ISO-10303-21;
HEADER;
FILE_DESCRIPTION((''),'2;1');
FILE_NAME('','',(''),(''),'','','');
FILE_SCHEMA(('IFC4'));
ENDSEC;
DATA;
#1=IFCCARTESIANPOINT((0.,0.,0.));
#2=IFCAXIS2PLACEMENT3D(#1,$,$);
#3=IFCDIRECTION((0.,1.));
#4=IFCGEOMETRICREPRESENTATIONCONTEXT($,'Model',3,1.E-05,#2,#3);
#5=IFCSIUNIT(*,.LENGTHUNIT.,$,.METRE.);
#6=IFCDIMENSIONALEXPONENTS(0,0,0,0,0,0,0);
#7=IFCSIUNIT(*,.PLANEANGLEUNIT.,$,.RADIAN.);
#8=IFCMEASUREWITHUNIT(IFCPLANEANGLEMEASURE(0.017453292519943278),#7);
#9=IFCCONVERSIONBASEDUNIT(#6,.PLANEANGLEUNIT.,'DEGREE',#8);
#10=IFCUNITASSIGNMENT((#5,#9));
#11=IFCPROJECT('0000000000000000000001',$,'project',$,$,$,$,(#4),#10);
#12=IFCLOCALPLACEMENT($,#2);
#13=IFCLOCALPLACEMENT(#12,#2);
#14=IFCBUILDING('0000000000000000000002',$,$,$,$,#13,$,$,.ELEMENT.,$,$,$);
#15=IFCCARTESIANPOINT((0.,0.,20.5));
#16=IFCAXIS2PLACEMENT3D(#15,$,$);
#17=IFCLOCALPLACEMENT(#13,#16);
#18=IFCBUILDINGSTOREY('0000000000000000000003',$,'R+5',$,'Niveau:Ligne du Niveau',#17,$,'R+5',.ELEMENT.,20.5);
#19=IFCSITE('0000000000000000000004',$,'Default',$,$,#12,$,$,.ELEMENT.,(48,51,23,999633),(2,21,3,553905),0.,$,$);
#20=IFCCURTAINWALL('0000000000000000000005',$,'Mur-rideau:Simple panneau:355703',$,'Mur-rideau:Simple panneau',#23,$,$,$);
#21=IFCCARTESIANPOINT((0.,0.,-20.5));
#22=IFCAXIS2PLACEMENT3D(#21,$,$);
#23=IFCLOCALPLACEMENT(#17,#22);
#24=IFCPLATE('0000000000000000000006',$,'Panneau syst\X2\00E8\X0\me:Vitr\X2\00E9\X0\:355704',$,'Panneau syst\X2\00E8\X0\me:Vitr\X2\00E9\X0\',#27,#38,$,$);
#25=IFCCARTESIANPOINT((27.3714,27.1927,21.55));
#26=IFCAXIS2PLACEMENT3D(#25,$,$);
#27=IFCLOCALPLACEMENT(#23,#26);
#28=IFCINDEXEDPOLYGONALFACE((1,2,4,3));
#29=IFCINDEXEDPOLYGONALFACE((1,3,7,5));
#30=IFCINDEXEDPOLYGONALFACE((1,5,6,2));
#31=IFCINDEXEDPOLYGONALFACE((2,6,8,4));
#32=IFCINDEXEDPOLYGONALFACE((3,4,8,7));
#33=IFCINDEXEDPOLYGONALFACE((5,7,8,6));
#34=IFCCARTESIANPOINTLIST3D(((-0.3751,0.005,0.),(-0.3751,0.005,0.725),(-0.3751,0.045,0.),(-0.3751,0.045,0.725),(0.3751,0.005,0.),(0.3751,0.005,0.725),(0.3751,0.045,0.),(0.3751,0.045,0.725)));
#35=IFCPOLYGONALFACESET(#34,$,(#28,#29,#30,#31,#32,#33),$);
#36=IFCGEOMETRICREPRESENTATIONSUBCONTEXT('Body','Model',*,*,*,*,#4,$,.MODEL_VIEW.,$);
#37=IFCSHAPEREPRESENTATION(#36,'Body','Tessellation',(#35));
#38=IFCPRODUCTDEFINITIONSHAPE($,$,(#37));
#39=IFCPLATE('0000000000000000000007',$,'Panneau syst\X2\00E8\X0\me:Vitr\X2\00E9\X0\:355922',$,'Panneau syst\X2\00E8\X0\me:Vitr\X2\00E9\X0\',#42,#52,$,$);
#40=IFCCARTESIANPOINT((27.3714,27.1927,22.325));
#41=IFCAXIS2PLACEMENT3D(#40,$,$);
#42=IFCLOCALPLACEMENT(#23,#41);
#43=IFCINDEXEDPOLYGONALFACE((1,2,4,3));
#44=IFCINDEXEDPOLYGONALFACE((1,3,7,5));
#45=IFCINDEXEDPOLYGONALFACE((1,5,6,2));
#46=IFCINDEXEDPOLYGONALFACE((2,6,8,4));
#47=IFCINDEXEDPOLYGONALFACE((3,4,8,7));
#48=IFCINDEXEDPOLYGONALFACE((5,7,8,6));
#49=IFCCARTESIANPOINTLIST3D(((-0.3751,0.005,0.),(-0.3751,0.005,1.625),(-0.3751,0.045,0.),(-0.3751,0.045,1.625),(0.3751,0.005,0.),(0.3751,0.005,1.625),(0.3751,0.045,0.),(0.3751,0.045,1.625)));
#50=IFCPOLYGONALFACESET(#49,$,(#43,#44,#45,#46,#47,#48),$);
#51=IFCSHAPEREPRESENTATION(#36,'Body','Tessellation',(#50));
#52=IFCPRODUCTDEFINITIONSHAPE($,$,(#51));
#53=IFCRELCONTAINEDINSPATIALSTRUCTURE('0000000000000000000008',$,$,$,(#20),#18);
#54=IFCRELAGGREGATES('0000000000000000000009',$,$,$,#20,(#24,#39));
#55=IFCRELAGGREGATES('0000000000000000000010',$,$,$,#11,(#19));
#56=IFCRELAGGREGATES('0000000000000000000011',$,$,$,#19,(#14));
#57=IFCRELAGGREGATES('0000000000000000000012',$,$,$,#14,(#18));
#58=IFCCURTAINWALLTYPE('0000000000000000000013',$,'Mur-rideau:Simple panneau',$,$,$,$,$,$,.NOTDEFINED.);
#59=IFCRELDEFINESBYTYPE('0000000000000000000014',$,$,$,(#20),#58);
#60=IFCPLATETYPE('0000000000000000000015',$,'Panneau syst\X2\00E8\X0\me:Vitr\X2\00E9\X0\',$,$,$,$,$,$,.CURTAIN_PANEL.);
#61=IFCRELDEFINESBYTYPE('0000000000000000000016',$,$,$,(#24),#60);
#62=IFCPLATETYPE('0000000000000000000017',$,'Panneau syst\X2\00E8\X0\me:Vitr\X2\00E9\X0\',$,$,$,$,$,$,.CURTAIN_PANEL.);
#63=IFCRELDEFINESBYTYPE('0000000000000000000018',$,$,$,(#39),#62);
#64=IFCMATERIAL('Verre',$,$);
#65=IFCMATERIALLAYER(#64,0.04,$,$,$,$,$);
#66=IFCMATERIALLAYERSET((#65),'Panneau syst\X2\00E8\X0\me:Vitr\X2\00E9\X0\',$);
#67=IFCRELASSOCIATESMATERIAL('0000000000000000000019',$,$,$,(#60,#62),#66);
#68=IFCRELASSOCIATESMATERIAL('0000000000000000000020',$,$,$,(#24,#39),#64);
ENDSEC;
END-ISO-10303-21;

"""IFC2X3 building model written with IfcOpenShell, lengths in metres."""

from ifc_helpers import new_model, entity, si_unit, converted_unit, direction, frame, frame_2d, origin, place, context, subcontext, project, spatial, rectangle, extrude, source, transform, mapped, material, layer, layer_set, type_object, type_shapes, element, aggregate, save


model = new_model("IFC2X3")

# Units and contexts
model_context = context("Model", 3, precision=1e-05, world=origin(), true_north=direction((0.0, 1.0)))
body_context = subcontext(model_context, "Body", "Model", "MODEL_VIEW")
ifc_project = project(units=[si_unit("LENGTHUNIT", "METRE"), converted_unit("PLANEANGLEUNIT", "DEGREE", entity("IfcPlaneAngleMeasure", 0.017453292519943278), si_unit("PLANEANGLEUNIT", "RADIAN"), dimensions=[0, 0, 0, 0, 0, 0, 0])], contexts=[model_context])

# Site, building, storey
site_placement = place(None, origin())
site = spatial("IfcSite", under=ifc_project, at=site_placement, Name="Default", CompositionType="ELEMENT", RefLatitude=(48, 51, 23, 999633), RefLongitude=(2, 21, 3, 553905), RefElevation=0.0)
building_placement = place(site_placement, origin())
building = spatial("IfcBuilding", under=site, at=building_placement, CompositionType="ELEMENT")
storey_placement = place(building_placement, frame((0.0, 0.0, 20.5)))
storey = spatial("IfcBuildingStorey", under=building, at=storey_placement, Name="R+5", ObjectType="Niveau:Ligne du Niveau", LongName="R+5", CompositionType="ELEMENT", Elevation=20.5)

# Shared definitions
curtain_wall_type = type_object("IfcCurtainWallType", Name="Mur-rideau:Simple panneau", PredefinedType="NOTDEFINED")

# Curtain wall
curtain_wall_1_placement = place(storey_placement, frame((0.0, 0.0, -20.5)))
curtain_wall_1 = element("IfcCurtainWall", 1, at=curtain_wall_1_placement, inside=storey, type_object=curtain_wall_type, Name="Mur-rideau:Simple panneau:355703", ObjectType="Mur-rideau:Simple panneau")

# Plates
ifc_material_1 = material(Name="Verre")
ifc_layer_1 = layer(ifc_material_1, 0.04)
ifc_layer_set_1 = layer_set([ifc_layer_1], Name="Panneau système:Vitré")
plate_type_1 = type_object("IfcPlateType", Name="Panneau système:Vitré", PredefinedType="CURTAIN_PANEL", material=ifc_layer_set_1)
shared_shape_1 = source(origin(), body_context, "Body", "SweptSolid", [
    extrude(rectangle(XDim=0.04, YDim=0.7503, at=frame_2d((0.0, 0.0), x_axis=(1.0, 0.0))), frame((0.0, 0.025, 0.0), z_axis=(0.0, 0.0, 1.0), x_axis=(0.0, 1.0, 0.0)), (0.0, 0.0, 1.0), 0.725),
])
type_shapes(plate_type_1, [shared_shape_1])
plate_1_placement = place(curtain_wall_1_placement, frame((27.3714, 27.1927, 21.55)))
plate_1 = element("IfcPlate", 2, at=plate_1_placement, type_object=plate_type_1, material=ifc_material_1, Name="Panneau système:Vitré:355704", ObjectType="Panneau système:Vitré", context=body_context, shape_type="MappedRepresentation", body=[
    mapped(shared_shape_1, transform((0.0, 0.0, 0.0), scale=1.0)),
])
plate_type_2 = type_object("IfcPlateType", Name="Panneau système:Vitré", PredefinedType="CURTAIN_PANEL", material=ifc_layer_set_1)
shared_shape_2 = source(origin(), body_context, "Body", "SweptSolid", [
    extrude(rectangle(XDim=0.04, YDim=0.7503, at=frame_2d((0.0, 0.0), x_axis=(1.0, 0.0))), frame((0.0, 0.025, 0.0), z_axis=(0.0, 0.0, 1.0), x_axis=(0.0, 1.0, 0.0)), (0.0, 0.0, 1.0), 1.625),
])
type_shapes(plate_type_2, [shared_shape_2])
plate_2_placement = place(curtain_wall_1_placement, frame((27.3714, 27.1927, 22.325)))
plate_2 = element("IfcPlate", 3, at=plate_2_placement, type_object=plate_type_2, material=ifc_material_1, Name="Panneau système:Vitré:355922", ObjectType="Panneau système:Vitré", context=body_context, shape_type="MappedRepresentation", body=[
    mapped(shared_shape_2, transform((0.0, 0.0, 0.0), scale=1.0)),
])
aggregate(curtain_wall_1, [plate_1, plate_2])

save(model, "model.ifc")
